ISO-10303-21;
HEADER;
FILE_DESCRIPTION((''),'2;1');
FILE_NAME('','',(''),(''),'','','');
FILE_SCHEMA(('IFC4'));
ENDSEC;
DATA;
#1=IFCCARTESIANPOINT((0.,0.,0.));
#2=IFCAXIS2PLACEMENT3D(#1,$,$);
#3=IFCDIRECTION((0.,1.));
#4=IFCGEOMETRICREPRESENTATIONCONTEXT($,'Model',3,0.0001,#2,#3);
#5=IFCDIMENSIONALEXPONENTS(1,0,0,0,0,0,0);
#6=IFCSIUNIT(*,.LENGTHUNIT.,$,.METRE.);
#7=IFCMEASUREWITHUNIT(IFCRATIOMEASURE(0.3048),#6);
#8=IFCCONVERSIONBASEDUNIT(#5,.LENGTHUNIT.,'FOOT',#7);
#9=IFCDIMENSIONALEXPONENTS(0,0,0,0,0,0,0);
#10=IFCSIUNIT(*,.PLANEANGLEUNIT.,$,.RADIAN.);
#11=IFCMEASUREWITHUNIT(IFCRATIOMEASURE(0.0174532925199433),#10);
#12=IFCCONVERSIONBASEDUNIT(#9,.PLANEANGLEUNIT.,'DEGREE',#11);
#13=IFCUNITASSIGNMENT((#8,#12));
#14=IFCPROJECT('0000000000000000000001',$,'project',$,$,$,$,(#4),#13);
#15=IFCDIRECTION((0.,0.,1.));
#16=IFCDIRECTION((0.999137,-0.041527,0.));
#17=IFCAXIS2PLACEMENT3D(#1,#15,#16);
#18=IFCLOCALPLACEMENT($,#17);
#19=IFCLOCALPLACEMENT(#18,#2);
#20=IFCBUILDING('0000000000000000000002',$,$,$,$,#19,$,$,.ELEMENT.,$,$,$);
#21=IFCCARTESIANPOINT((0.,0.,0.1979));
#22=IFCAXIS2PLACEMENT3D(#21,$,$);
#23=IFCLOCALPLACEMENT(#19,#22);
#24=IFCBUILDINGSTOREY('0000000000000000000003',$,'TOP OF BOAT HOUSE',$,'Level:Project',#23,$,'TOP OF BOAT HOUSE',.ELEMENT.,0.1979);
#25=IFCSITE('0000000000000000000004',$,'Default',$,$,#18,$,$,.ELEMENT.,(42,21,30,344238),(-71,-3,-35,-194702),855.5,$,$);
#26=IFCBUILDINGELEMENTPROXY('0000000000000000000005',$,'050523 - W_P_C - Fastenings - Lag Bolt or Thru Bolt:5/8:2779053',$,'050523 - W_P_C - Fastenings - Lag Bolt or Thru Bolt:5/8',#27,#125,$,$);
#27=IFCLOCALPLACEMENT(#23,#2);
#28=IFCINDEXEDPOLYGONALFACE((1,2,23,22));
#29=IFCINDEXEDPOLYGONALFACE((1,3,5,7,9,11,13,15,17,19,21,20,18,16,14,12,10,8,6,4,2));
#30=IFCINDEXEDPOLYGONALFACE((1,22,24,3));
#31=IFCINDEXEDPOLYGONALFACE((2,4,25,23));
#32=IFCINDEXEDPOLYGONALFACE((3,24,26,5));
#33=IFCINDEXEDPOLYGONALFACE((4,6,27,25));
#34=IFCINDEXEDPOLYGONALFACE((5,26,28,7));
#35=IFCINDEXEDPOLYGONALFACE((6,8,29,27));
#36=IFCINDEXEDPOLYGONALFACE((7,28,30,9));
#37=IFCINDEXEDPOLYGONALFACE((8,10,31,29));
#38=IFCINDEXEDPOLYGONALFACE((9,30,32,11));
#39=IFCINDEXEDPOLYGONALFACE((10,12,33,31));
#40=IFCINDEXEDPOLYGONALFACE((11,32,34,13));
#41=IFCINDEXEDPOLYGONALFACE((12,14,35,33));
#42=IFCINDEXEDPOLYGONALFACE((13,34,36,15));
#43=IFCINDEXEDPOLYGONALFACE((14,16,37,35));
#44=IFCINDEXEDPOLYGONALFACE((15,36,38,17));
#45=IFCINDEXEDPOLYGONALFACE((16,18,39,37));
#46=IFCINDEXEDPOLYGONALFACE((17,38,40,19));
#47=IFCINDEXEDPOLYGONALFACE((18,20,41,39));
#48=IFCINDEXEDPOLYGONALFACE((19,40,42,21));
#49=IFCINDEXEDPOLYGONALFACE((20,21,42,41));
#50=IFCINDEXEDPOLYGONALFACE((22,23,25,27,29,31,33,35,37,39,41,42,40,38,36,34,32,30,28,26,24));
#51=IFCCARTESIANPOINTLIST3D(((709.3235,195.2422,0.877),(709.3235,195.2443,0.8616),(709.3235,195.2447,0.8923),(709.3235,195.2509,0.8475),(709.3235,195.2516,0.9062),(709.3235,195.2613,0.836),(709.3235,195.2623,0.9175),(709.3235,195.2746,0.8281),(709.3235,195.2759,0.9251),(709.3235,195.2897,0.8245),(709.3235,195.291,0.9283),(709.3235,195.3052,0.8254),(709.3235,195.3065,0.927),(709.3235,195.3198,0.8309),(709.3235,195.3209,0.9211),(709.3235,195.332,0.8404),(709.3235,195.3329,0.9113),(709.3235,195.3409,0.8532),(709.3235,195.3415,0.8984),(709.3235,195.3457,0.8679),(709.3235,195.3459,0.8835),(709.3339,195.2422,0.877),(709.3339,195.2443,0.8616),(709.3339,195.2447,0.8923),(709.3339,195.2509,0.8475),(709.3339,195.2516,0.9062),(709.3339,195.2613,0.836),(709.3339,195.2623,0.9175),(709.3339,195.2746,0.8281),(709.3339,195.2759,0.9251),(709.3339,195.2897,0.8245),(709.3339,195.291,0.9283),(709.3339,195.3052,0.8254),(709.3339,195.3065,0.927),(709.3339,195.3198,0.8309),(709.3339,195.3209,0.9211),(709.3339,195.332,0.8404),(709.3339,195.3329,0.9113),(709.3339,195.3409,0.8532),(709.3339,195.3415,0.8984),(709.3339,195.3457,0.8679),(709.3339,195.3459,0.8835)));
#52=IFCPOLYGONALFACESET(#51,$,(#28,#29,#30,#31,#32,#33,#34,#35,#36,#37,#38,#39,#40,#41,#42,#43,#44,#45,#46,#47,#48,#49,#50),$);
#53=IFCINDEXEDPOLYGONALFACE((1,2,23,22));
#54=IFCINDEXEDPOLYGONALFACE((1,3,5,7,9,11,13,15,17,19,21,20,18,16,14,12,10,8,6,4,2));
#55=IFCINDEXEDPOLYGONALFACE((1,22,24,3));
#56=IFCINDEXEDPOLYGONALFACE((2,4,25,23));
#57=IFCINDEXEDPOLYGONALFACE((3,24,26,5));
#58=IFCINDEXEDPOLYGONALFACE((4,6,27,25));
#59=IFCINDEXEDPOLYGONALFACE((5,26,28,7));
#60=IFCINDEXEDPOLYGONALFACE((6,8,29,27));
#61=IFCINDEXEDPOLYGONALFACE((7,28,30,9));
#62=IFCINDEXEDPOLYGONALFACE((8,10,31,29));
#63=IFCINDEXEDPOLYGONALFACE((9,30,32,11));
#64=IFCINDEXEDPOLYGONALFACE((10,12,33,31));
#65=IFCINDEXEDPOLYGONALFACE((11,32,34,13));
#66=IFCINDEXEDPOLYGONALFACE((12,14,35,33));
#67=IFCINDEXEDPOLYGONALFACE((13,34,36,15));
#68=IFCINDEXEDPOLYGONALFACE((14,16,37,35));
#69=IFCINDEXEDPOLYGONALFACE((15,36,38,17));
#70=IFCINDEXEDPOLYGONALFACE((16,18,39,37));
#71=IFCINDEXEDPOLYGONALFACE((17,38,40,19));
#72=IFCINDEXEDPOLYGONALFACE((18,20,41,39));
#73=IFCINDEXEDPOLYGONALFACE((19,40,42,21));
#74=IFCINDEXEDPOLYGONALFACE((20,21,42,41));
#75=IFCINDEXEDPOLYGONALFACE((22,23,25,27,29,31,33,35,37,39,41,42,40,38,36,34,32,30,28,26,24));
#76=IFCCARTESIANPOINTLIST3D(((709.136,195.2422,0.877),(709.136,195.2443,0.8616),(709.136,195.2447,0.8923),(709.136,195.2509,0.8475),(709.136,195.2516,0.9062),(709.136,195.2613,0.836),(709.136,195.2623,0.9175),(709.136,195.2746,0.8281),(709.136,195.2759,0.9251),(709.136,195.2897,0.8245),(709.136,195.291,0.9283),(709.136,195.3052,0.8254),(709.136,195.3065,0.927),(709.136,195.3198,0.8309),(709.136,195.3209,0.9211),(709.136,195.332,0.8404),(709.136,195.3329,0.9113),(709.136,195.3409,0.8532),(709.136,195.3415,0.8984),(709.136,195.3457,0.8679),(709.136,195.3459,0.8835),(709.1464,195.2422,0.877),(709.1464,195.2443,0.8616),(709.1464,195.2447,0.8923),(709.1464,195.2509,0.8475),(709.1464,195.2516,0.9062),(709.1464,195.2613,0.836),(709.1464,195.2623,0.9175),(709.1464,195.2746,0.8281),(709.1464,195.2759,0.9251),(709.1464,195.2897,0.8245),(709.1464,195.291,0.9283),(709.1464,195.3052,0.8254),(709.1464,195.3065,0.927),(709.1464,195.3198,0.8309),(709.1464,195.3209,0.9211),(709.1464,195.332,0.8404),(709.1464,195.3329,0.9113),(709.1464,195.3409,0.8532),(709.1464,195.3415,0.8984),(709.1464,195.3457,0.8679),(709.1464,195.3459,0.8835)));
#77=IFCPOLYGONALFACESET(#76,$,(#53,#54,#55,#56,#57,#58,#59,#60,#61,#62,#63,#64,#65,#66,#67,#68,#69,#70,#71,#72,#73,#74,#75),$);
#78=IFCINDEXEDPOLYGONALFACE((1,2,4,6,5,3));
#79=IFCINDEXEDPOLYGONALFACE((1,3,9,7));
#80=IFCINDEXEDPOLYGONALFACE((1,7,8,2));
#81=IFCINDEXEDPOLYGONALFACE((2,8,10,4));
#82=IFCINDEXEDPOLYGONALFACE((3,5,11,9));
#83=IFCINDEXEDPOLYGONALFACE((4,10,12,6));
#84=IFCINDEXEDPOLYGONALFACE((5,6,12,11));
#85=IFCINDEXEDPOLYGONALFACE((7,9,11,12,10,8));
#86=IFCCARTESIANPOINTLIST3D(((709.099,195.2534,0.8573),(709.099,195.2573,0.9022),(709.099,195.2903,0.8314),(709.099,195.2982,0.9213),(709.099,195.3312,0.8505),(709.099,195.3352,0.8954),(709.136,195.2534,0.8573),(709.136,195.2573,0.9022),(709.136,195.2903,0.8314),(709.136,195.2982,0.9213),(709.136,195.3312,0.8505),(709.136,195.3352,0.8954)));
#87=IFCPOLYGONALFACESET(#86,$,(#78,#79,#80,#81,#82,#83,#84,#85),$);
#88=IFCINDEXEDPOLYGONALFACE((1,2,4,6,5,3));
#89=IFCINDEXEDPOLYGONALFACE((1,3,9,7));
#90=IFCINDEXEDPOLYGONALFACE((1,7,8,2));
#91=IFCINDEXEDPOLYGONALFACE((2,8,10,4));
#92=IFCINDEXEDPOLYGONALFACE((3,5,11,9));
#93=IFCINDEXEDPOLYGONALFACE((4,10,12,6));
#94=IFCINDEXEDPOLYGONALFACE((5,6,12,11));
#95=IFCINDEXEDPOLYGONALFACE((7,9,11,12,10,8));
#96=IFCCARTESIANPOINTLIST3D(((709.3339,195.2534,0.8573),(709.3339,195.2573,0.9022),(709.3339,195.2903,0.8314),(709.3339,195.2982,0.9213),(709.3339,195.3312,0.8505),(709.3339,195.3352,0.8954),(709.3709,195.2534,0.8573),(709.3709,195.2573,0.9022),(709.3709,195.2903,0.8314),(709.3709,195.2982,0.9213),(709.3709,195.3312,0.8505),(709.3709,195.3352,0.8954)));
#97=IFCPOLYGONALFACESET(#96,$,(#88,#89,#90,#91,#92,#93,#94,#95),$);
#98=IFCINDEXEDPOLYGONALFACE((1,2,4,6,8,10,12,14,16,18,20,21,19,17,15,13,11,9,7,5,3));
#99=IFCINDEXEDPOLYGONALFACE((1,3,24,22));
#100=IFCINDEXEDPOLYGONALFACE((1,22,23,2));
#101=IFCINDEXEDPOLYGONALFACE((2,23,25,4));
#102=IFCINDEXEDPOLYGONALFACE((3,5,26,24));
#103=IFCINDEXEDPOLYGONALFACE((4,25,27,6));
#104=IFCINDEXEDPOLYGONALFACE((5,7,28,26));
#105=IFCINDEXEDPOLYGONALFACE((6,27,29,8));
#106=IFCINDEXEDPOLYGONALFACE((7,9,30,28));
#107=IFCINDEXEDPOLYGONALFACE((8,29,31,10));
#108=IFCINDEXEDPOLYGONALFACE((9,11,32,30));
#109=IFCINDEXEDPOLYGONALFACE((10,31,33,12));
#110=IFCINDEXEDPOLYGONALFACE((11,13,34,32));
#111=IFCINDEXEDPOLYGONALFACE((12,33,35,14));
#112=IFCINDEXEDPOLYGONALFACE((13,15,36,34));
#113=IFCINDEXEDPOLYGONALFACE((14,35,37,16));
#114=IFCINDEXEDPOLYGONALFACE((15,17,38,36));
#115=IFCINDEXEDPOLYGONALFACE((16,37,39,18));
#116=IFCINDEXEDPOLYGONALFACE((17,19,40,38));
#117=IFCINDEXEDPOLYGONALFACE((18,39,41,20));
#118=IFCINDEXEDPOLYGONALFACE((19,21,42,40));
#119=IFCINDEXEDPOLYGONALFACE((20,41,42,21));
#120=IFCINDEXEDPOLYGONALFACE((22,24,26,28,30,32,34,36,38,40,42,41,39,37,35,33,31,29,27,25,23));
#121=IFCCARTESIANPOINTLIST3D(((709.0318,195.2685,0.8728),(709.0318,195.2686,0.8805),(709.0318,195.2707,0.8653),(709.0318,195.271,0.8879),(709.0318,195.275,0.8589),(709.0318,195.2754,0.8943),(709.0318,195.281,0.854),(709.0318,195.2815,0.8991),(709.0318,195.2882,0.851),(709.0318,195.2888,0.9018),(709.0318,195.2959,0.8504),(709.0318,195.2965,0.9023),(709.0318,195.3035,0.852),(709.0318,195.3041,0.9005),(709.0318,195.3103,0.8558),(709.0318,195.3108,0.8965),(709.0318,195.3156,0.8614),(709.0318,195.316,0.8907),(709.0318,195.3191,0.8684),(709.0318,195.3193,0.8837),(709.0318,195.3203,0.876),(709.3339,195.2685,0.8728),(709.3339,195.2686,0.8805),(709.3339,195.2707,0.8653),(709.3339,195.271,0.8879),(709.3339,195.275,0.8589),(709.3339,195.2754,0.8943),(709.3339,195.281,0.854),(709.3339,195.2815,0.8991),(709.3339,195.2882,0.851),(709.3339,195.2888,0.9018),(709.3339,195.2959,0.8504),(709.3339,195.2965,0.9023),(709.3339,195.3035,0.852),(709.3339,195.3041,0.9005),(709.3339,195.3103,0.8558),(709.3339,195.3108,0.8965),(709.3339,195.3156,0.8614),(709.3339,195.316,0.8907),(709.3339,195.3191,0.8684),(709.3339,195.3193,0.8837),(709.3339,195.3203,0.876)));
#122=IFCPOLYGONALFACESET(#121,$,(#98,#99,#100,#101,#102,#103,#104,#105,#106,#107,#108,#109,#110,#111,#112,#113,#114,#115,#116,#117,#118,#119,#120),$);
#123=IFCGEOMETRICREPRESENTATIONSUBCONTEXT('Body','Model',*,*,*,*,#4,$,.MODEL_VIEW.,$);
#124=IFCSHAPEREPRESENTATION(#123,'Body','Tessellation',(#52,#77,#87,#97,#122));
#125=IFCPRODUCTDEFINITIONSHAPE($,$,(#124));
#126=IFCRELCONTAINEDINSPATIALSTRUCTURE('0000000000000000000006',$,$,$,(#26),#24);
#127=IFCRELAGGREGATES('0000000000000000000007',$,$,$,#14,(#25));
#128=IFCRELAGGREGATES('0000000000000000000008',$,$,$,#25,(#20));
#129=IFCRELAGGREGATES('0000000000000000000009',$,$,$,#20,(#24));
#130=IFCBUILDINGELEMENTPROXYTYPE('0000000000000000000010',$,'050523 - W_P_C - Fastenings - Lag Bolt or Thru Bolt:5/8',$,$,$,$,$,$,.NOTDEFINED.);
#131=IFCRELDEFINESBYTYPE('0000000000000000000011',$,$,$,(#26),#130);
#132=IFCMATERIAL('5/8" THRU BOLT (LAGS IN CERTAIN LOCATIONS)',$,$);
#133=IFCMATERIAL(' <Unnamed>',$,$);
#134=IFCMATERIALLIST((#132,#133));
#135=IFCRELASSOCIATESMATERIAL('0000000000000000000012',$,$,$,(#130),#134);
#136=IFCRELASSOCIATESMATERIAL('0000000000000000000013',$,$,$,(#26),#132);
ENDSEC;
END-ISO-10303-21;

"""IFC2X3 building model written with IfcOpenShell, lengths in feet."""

from ifc_helpers import new_model, entity, si_unit, converted_unit, direction, frame, frame_2d, origin, place, context, subcontext, project, spatial, polyline, circle, outline, extrude, source, transform, mapped, material, material_list, type_object, type_shapes, element, save


model = new_model("IFC2X3")

# Units and contexts
model_context = context("Model", 3, precision=0.0001, world=origin(), true_north=direction((0.0, 1.0)))
body_context = subcontext(model_context, "Body", "Model", "MODEL_VIEW")
ifc_project = project(units=[converted_unit("LENGTHUNIT", "FOOT", entity("IfcRatioMeasure", 0.3048), si_unit("LENGTHUNIT", "METRE"), dimensions=[1, 0, 0, 0, 0, 0, 0]), converted_unit("PLANEANGLEUNIT", "DEGREE", entity("IfcRatioMeasure", 0.0174532925199433), si_unit("PLANEANGLEUNIT", "RADIAN"), dimensions=[0, 0, 0, 0, 0, 0, 0])], contexts=[model_context])

# Site, building, storey
site_placement = place(None, frame((0.0, 0.0, 0.0), z_axis=(0.0, 0.0, 1.0), x_axis=(0.999137, -0.041527, 0.0)))
site = spatial("IfcSite", under=ifc_project, at=site_placement, Name="Default", CompositionType="ELEMENT", RefLatitude=(42, 21, 30, 344238), RefLongitude=(-71, -3, -35, -194702), RefElevation=855.5)
building_placement = place(site_placement, origin())
building = spatial("IfcBuilding", under=site, at=building_placement, CompositionType="ELEMENT")
storey_placement = place(building_placement, frame((0.0, 0.0, 0.1979)))
storey = spatial("IfcBuildingStorey", under=building, at=storey_placement, Name="TOP OF BOAT HOUSE", ObjectType="Level:Project", LongName="TOP OF BOAT HOUSE", CompositionType="ELEMENT", Elevation=0.1979)

# Building element proxy
ifc_material_1 = material(Name="5/8\" THRU BOLT (LAGS IN CERTAIN LOCATIONS)")
ifc_material_2 = material(Name=" <Unnamed>")
ifc_material_list_1 = material_list([ifc_material_1, ifc_material_2])
building_element_proxy_type_1 = type_object("IfcBuildingElementProxyType", Name="050523 - W_P_C - Fastenings - Lag Bolt or Thru Bolt:5/8", PredefinedType="NOTDEFINED", material=ifc_material_list_1)
shared_shape_1 = source(origin(), body_context, "Body", "SweptSolid", [
    extrude(circle(Radius=0.0521, at=frame_2d((0.0, 0.0), x_axis=(1.0, 0.0))), frame((0.0, 0.0, 0.0), z_axis=(0.0, 0.0, 1.0), x_axis=(0.0, -1.0, 0.0)), (0.0, 0.0, 1.0), 0.0104),
    extrude(circle(Radius=0.0521, at=frame_2d((0.0, 0.0), x_axis=(1.0, 0.0))), frame((0.0, 0.0, -0.1875), z_axis=(0.0, 0.0, 1.0), x_axis=(0.0, -1.0, 0.0)), (0.0, 0.0, 1.0), 0.0104),
    extrude(outline(polyline([(-0.0226, -0.0391), (0.0226, -0.0391), (0.0451, 0.0), (0.0226, 0.0391), (-0.0226, 0.0391), (-0.0451, 0.0), (-0.0226, -0.0391)])), frame((0.0, 0.0, -0.2245), z_axis=(0.0, 0.0, 1.0), x_axis=(0.866025, -0.5, 0.0)), (0.0, 0.0, 1.0), 0.037),
    extrude(outline(polyline([(-0.0226, -0.0391), (0.0226, -0.0391), (0.0451, 0.0), (0.0226, 0.0391), (-0.0226, 0.0391), (-0.0451, 0.0), (-0.0226, -0.0391)])), frame((0.0, 0.0, 0.0104), z_axis=(0.0, 0.0, 1.0), x_axis=(0.0, -1.0, 0.0)), (0.0, 0.0, 1.0), 0.037),
    extrude(circle(Radius=0.026, at=frame_2d((0.0, 0.0), x_axis=(1.0, 0.0))), frame((0.0, 0.0, -0.2917), z_axis=(0.0, 0.0, 1.0), x_axis=(0.0, 1.0, 0.0)), (0.0, 0.0, 1.0), 0.3021),
])
type_shapes(building_element_proxy_type_1, [shared_shape_1])
for number, where, z_axis, x_axis, name in (
    (1, (709.3235, 195.2943, 0.8763), (1.0, 0.0, 0.0), (0.0, 0.996195, -0.087156), "050523 - W_P_C - Fastenings - Lag Bolt or Thru Bolt:5/8:2779053"),
):
    element("IfcBuildingElementProxy", number, at=place(storey_placement, frame(where, z_axis=z_axis, x_axis=x_axis)), inside=storey, type_object=building_element_proxy_type_1, material=ifc_material_1, Name=name, ObjectType="050523 - W_P_C - Fastenings - Lag Bolt or Thru Bolt:5/8", context=body_context, shape_type="MappedRepresentation", body=[
        mapped(shared_shape_1, transform((0.0, 0.0, 0.0), scale=1.0)),
    ])

save(model, "model.ifc")
